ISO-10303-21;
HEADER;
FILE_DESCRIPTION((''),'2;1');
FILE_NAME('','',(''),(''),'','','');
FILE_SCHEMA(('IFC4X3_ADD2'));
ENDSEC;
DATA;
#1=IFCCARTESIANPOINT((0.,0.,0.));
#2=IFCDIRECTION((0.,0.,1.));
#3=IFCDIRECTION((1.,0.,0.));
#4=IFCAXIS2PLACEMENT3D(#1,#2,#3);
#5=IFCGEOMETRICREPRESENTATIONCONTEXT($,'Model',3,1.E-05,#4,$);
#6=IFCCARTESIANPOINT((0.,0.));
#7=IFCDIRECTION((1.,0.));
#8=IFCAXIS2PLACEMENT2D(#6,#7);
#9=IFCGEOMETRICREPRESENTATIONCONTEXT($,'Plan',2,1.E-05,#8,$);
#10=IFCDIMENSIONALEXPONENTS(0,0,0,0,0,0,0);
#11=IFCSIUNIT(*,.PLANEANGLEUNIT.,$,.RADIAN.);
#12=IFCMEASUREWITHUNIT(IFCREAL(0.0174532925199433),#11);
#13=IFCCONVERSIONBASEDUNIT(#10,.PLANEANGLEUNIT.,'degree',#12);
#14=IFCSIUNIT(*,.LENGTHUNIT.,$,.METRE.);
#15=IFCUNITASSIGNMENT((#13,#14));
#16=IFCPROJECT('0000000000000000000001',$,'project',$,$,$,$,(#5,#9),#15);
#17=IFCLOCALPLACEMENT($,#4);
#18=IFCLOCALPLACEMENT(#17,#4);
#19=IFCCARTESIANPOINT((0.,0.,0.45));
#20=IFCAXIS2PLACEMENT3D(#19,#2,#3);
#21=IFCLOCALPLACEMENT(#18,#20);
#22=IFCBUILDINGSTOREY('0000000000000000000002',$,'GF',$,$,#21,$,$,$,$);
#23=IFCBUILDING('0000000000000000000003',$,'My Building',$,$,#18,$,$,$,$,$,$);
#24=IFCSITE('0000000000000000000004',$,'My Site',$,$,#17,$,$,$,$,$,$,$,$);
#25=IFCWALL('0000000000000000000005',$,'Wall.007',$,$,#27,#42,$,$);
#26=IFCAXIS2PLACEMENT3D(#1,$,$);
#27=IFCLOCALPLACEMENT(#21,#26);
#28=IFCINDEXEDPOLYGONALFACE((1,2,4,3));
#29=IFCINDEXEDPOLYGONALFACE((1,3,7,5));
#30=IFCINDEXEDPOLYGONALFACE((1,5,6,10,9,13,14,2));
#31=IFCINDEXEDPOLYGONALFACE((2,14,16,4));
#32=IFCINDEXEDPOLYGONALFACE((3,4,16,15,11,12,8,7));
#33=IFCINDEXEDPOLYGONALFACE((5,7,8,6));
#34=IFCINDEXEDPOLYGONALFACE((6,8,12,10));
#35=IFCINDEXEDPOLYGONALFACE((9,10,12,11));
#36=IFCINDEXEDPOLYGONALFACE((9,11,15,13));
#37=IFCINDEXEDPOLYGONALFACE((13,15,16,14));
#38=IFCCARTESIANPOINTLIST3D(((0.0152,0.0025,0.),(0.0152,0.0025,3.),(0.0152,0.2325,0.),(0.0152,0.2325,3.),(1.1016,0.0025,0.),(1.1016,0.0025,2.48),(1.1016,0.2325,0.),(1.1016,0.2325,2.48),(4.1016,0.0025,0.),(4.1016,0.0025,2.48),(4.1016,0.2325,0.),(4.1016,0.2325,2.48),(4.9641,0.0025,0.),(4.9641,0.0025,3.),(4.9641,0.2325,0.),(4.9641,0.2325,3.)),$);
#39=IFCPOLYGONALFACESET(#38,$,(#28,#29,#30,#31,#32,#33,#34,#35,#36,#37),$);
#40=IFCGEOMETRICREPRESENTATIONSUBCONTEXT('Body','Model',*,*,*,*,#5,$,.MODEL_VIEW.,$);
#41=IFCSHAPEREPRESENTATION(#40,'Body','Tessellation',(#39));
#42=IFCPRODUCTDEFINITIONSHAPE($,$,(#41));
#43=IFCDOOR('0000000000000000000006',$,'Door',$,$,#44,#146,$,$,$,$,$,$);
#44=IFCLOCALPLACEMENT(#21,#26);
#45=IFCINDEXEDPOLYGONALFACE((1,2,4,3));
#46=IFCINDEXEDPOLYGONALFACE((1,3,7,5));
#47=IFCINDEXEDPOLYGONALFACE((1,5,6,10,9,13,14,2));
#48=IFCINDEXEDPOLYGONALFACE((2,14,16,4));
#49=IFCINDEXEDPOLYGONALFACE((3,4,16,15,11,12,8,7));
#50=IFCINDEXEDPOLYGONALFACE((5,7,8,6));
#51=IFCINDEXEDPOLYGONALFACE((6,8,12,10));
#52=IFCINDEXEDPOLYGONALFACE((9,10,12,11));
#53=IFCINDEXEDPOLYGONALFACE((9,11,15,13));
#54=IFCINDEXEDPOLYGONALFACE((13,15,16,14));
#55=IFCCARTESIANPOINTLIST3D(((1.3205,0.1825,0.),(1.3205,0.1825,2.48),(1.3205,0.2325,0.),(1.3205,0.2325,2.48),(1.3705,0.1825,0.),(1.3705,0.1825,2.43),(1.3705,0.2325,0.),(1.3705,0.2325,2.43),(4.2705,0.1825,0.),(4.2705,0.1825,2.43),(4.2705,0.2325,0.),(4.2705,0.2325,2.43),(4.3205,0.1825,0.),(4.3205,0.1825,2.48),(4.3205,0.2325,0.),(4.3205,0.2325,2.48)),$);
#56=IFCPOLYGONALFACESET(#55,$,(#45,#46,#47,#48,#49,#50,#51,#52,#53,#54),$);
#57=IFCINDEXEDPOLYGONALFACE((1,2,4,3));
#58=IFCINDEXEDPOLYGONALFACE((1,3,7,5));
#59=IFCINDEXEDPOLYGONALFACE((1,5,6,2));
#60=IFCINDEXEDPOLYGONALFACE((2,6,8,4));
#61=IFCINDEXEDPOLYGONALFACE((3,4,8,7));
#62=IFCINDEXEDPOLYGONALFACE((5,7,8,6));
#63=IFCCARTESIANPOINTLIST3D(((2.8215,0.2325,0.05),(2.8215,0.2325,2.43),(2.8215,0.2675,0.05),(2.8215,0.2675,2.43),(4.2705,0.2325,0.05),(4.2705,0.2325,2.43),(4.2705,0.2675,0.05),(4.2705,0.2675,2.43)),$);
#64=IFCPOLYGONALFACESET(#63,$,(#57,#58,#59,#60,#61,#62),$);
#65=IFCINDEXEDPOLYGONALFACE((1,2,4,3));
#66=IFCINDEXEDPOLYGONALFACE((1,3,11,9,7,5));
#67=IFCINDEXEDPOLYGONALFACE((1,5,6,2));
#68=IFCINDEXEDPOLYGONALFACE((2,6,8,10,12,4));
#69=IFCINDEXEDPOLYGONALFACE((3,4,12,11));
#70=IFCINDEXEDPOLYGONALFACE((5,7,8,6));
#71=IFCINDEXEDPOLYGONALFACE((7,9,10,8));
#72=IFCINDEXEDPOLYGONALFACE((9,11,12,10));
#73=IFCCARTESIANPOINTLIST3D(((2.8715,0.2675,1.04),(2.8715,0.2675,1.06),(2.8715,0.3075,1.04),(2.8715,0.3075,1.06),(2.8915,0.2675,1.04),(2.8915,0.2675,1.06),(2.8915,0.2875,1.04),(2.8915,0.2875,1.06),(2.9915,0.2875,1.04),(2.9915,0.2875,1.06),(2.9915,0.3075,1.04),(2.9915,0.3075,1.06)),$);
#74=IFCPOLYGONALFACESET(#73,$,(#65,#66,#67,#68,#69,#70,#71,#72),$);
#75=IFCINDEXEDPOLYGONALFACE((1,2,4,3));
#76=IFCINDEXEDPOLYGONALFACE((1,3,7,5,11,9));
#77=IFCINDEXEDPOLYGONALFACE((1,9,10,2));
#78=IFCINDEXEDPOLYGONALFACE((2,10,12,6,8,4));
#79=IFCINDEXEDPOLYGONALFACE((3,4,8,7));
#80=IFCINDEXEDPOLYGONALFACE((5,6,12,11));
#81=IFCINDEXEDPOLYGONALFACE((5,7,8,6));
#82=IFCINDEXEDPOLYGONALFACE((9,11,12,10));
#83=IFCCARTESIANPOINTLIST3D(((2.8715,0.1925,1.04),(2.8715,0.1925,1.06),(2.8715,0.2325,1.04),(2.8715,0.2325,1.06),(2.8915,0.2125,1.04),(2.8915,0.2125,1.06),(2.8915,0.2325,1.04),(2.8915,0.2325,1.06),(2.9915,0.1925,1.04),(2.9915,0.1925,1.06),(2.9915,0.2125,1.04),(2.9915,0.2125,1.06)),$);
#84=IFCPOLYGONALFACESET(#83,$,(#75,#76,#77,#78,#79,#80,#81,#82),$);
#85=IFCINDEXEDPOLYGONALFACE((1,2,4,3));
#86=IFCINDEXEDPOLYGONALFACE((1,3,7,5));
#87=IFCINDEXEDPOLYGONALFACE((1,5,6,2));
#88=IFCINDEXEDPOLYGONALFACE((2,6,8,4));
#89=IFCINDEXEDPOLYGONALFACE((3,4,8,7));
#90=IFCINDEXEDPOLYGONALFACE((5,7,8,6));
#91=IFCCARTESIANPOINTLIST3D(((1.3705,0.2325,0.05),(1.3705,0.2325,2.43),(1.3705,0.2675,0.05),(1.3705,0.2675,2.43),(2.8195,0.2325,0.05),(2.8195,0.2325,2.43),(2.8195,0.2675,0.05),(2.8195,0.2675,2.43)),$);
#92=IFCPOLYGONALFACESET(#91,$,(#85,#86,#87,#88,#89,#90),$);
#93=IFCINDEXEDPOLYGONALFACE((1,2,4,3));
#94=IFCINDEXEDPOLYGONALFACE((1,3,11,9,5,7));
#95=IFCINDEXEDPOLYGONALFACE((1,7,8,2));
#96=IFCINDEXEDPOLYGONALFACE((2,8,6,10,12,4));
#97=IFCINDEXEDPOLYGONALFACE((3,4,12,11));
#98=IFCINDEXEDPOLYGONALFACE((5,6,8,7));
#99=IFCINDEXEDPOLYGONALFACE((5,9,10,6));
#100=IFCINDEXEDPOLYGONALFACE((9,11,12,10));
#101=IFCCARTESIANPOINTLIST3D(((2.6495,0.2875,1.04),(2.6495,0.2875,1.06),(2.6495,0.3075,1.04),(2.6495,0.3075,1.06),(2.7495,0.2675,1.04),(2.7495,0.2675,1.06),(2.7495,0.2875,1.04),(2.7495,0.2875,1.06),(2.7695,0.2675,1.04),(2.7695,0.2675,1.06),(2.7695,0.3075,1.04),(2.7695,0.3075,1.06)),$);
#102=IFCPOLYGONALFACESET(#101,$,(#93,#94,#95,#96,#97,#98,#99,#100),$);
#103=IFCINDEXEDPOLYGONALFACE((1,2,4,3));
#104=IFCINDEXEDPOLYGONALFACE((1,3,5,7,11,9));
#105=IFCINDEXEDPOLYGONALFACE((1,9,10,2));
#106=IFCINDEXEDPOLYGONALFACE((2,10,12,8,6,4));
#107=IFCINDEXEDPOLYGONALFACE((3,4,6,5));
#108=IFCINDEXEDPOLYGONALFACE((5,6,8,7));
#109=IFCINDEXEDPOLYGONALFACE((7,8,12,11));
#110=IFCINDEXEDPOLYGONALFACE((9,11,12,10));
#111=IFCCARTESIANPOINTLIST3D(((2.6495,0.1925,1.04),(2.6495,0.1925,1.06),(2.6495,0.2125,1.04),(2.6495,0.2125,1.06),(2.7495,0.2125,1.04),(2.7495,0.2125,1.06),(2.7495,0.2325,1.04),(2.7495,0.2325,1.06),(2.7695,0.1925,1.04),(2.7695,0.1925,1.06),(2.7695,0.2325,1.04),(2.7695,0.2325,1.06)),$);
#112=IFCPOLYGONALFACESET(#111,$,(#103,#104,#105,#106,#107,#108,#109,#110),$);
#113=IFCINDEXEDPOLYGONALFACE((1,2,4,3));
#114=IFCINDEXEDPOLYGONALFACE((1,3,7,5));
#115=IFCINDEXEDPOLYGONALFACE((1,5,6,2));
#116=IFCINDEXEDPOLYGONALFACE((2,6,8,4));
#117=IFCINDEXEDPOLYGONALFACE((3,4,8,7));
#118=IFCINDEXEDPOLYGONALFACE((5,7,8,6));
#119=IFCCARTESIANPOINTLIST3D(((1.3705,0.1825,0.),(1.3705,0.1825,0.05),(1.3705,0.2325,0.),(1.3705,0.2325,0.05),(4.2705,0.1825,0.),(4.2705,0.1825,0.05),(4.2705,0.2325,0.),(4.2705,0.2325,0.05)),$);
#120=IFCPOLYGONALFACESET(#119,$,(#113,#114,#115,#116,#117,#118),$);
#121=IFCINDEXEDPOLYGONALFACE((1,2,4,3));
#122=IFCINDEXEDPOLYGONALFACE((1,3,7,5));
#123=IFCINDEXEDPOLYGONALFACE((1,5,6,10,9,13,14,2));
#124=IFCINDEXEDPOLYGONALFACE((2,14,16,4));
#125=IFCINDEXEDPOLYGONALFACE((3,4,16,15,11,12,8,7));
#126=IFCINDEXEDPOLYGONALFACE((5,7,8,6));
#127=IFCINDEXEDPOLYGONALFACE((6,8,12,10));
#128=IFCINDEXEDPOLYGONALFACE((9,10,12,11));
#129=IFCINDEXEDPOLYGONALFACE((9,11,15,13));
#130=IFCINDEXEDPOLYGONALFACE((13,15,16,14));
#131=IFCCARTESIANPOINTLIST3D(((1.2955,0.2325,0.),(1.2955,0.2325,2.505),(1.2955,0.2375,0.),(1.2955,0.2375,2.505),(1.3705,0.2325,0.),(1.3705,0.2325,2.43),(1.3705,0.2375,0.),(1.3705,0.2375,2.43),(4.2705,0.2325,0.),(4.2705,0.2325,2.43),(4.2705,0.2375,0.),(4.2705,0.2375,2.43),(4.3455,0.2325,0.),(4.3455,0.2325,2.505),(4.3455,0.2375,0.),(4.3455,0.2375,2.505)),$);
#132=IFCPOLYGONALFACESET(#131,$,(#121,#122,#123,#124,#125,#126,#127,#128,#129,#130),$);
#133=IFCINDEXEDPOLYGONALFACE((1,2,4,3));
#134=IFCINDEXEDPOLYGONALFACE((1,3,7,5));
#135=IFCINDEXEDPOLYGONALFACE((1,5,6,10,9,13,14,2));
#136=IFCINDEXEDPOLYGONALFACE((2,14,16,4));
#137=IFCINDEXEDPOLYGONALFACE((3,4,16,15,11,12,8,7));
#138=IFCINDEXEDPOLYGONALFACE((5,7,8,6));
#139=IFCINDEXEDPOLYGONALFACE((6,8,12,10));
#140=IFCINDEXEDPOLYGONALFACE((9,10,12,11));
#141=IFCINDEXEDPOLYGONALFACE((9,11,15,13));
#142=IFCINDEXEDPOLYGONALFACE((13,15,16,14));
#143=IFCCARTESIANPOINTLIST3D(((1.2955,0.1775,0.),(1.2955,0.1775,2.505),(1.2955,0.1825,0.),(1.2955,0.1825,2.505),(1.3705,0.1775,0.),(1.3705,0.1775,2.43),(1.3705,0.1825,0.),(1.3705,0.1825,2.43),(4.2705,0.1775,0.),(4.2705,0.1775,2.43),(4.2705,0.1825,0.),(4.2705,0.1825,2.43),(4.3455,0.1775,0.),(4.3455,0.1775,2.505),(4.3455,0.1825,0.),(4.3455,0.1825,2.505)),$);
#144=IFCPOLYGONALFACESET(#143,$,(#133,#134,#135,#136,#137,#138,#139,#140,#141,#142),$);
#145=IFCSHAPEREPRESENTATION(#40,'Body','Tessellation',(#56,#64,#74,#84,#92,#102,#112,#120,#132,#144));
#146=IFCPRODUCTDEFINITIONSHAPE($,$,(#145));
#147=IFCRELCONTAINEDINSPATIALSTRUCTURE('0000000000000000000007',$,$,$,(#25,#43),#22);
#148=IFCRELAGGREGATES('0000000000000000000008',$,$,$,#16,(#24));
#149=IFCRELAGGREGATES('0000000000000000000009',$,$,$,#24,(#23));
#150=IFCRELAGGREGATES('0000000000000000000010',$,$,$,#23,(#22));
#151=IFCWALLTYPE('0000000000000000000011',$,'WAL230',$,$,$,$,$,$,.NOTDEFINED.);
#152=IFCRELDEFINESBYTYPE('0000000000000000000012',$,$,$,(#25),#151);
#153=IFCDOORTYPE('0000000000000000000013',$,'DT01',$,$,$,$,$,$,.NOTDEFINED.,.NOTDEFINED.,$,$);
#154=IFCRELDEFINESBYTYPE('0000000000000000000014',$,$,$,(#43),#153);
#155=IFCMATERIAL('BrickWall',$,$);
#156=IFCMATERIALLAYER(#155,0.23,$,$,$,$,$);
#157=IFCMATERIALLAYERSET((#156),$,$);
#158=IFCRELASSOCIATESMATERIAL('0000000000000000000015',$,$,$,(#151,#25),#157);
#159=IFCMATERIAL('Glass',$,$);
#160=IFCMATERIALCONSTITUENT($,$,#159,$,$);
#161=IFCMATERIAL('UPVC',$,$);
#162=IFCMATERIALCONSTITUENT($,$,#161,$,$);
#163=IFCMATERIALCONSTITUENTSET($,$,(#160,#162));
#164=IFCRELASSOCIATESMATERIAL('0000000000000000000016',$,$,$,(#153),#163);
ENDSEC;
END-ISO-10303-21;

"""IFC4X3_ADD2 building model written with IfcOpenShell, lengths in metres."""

from ifc_helpers import new_model, entity, si_unit, converted_unit, frame, origin_with_axes, origin_2d_with_axis, place, context, subcontext, project, spatial, line, indexed_curve, outline, extrude, shape, source, transform, mapped, material, layer, layer_set, layer_usage, constituent, constituent_set, type_object, type_shapes, element, fill, save


model = new_model("IFC4X3_ADD2")

# Units and contexts
model_context = context("Model", 3, precision=1e-05, world=origin_with_axes())
plan_context = context("Plan", 2, precision=1e-05, world=origin_2d_with_axis())
body_context_1 = subcontext(model_context, "Body", "Model", "MODEL_VIEW")
body_context_2 = subcontext(plan_context, "Body", "Plan", "PLAN_VIEW")
ifc_project = project(units=[converted_unit("PLANEANGLEUNIT", "degree", entity("IfcReal", 0.0174532925199433), si_unit("PLANEANGLEUNIT", "RADIAN"), dimensions=[0, 0, 0, 0, 0, 0, 0]), si_unit("LENGTHUNIT", "METRE")], contexts=[model_context, plan_context])

# Site, building, storey
site_placement = place(None, origin_with_axes())
site = spatial("IfcSite", under=ifc_project, at=site_placement, Name="My Site")
building_placement = place(site_placement, origin_with_axes())
building = spatial("IfcBuilding", under=site, at=building_placement, Name="My Building")
storey_placement = place(building_placement, frame((0.0, 0.0, 0.45), z_axis=(0.0, 0.0, 1.0), x_axis=(1.0, 0.0, 0.0)))
storey = spatial("IfcBuildingStorey", under=building, at=storey_placement, Name="GF")

# Shared definitions
ifc_material_1 = material(Name="BrickWall")

# Shared definitions
ifc_layer_1 = layer(ifc_material_1, 0.23)
ifc_layer_set_1 = layer_set([ifc_layer_1])
wall_type_1 = type_object("IfcWallType", Name="WAL230", PredefinedType="NOTDEFINED", material=ifc_layer_set_1)
shared_shape_1 = source(origin_with_axes(), body_context_1, "Body", "SweptSolid", [
    extrude(outline(indexed_curve([(0.0, 0.0), (3.0, 0.0), (3.0, 2.48), (0.0, 2.48)], segments=[line(1, 2, 3, 4, 1)])), frame((0.0, -0.6, 0.0), z_axis=(0.0, -1.0, 0.0), x_axis=(1.0, 0.0, 0.0)), (0.0, 0.0, -1.0), 1.2),
])
ifc_material_2 = material(Name="Glass")
ifc_constituent_1 = constituent(ifc_material_2)
ifc_material_3 = material(Name="UPVC")
ifc_constituent_2 = constituent(ifc_material_3)
ifc_constituent_set = constituent_set(constituents=[ifc_constituent_1, ifc_constituent_2])
door_type_1 = type_object("IfcDoorType", Name="DT01", OperationType="NOTDEFINED", PredefinedType="NOTDEFINED", material=ifc_constituent_set)
shared_shape_2 = source(origin_with_axes(), body_context_1, "Body", "SweptSolid", [
    extrude(outline(indexed_curve([(3.0, 0.0), (3.0, 2.48), (0.0, 2.48), (0.0, 0.0), (0.05, 0.0), (0.05, 2.43), (2.95, 2.43), (2.95, 0.0)], segments=[line(5, 4), line(4, 3), line(3, 2), line(2, 1), line(1, 8), line(8, 7), line(7, 6), line(6, 5)], self_intersect=False)), frame((0.0, 0.0, 0.0), z_axis=(0.0, -1.0, 0.0), x_axis=(1.0, 0.0, 0.0)), (0.0, 0.0, -1.0), 0.05),
    extrude(outline(indexed_curve([(0.0, 0.0), (1.449, 0.0), (1.449, 0.035), (0.0, 0.035)], segments=[line(1, 2, 3, 4, 1)])), frame((0.05, -0.035, 0.05), z_axis=(0.0, 0.0, 1.0), x_axis=(1.0, 0.0, 0.0)), (0.0, 0.0, 1.0), 2.38),
    extrude(outline(indexed_curve([(0.0, 0.0), (0.0, -0.04), (-0.12, -0.04), (-0.12, -0.02), (-0.02, -0.02), (-0.02, 0.0)], segments=[line(1, 2, 3, 4, 5, 6, 1)])), frame((1.449, -0.035, 1.04), z_axis=(0.0, 0.0, 1.0), x_axis=(1.0, 0.0, 0.0)), (0.0, 0.0, 1.0), 0.02),
    extrude(outline(indexed_curve([(0.0, 0.0), (0.0, 0.04), (-0.12, 0.04), (-0.12, 0.02), (-0.02, 0.02), (-0.02, 0.0)], segments=[line(1, 2, 3, 4, 5, 6, 1)])), frame((1.449, 0.0, 1.04), z_axis=(0.0, 0.0, 1.0), x_axis=(1.0, 0.0, 0.0)), (0.0, 0.0, 1.0), 0.02),
    extrude(outline(indexed_curve([(0.0, 0.0), (-1.449, 0.0), (-1.449, 0.035), (0.0, 0.035)], segments=[line(1, 2, 3, 4, 1)])), frame((2.95, -0.035, 0.05), z_axis=(0.0, 0.0, 1.0), x_axis=(1.0, 0.0, 0.0)), (0.0, 0.0, 1.0), 2.38),
    extrude(outline(indexed_curve([(0.0, 0.0), (0.0, -0.04), (0.12, -0.04), (0.12, -0.02), (0.02, -0.02), (0.02, 0.0)], segments=[line(1, 2, 3, 4, 5, 6, 1)])), frame((1.551, -0.035, 1.04), z_axis=(0.0, 0.0, 1.0), x_axis=(1.0, 0.0, 0.0)), (0.0, 0.0, 1.0), 0.02),
    extrude(outline(indexed_curve([(0.0, 0.0), (0.0, 0.04), (0.12, 0.04), (0.12, 0.02), (0.02, 0.02), (0.02, 0.0)], segments=[line(1, 2, 3, 4, 5, 6, 1)])), frame((1.551, 0.0, 1.04), z_axis=(0.0, 0.0, 1.0), x_axis=(1.0, 0.0, 0.0)), (0.0, 0.0, 1.0), 0.02),
    extrude(outline(indexed_curve([(0.0, 0.0), (2.9, 0.0), (2.9, 0.05), (0.0, 0.05)], segments=[line(1, 2, 3, 4, 1)])), frame((0.05, 0.0, 0.0), z_axis=(0.0, 0.0, 1.0), x_axis=(1.0, 0.0, 0.0)), (0.0, 0.0, 1.0), 0.05),
    extrude(outline(indexed_curve([(0.0, 0.0), (0.0, 2.505), (3.05, 2.505), (3.05, 0.0), (2.975, 0.0), (2.975, 2.43), (0.075, 2.43), (0.075, 0.0)], segments=[line(1, 2, 3, 4, 5, 6, 7, 8, 1)])), frame((-0.025, -0.005, 0.0), z_axis=(0.0, -1.0, 0.0), x_axis=(1.0, 0.0, 0.0)), (0.0, 0.0, -1.0), 0.005),
    extrude(outline(indexed_curve([(0.0, 0.0), (0.0, 2.505), (3.05, 2.505), (3.05, 0.0), (2.975, 0.0), (2.975, 2.43), (0.075, 2.43), (0.075, 0.0)], segments=[line(1, 2, 3, 4, 5, 6, 7, 8, 1)])), frame((-0.025, 0.05, 0.0), z_axis=(0.0, -1.0, 0.0), x_axis=(1.0, 0.0, 0.0)), (0.0, 0.0, -1.0), 0.005),
])
shared_shape_3 = source(origin_with_axes(), body_context_2, "Body", "Curve2D", [
    entity("IfcIndexedPolyCurve", entity("IfcCartesianPointList2D", [[0.0, 0.0], [0.05, 0.0], [0.05, 0.05], [0.0, 0.05]]), [entity("IfcLineIndex", [1, 2, 3, 4, 1])]),
    entity("IfcIndexedPolyCurve", entity("IfcCartesianPointList2D", [[3.0, 0.0], [2.95, 0.0], [2.95, 0.05], [3.0, 0.05]]), [entity("IfcLineIndex", [1, 2, 3, 4, 1])]),
    entity("IfcIndexedPolyCurve", entity("IfcCartesianPointList2D", [[-0.675, -0.035], [0.775, -0.035], [0.775, 0.0], [-0.675, 0.0]]), [entity("IfcLineIndex", [1, 2, 3, 4, 1])]),
    entity("IfcIndexedPolyCurve", entity("IfcCartesianPointList2D", [[3.675, -0.035], [2.225, -0.035], [2.225, 0.0], [3.675, 0.0]]), [entity("IfcLineIndex", [1, 2, 3, 4, 1])]),
])
type_shapes(door_type_1, [shared_shape_2, shared_shape_3])

# Wall, opening, door
ifc_layer_usage_1 = layer_usage(ifc_layer_set_1, "AXIS2", "POSITIVE", 0.0)
wall_1_placement = place(storey_placement, frame((4.9641, 0.2325, 0.0), z_axis=(0.0, 0.0, 1.0), x_axis=(-1.0, 0.0, 0.0)))
wall_1 = element("IfcWall", 1, at=wall_1_placement, inside=storey, type_object=wall_type_1, material=ifc_layer_usage_1, Name="Wall.007", context=body_context_1, shape_type="SweptSolid", body=[
    extrude(outline(indexed_curve([(0.0, 0.0), (0.0, 0.23), (4.9489, 0.23), (4.9489, 0.0), (0.0, 0.0)], self_intersect=False)), origin_with_axes(), (0.0, 0.0, 1.0), 3.0),
])
opening_1_placement = place(wall_1_placement, frame((0.8625, 0.0175, 0.0), z_axis=(0.0, 0.0, 1.0), x_axis=(1.0, 0.0, 0.0)))
opening_1 = element("IfcOpeningElement", 2, at=opening_1_placement, cuts=wall_1, PredefinedType="OPENING", context=body_context_1, shape_type="MappedRepresentation", body=[
    mapped(shared_shape_1, transform((0.0, 0.0, 0.0), x_axis=(1.0, 0.0, 0.0), y_axis=(0.0, 1.0, 0.0), z_axis=(0.0, 0.0, 1.0), scale=1.0)),
])
door_1_placement = place(opening_1_placement, frame((-0.2189, -0.0175, 0.0), z_axis=(0.0, 0.0, 1.0), x_axis=(1.0, 0.0, 0.0)))
door_1 = element("IfcDoor", 3, at=door_1_placement, inside=storey, type_object=door_type_1, Name="Door", shapes=[
    shape(body_context_1, "Body", "MappedRepresentation", [mapped(shared_shape_2, transform((0.0, 0.0, 0.0), x_axis=(1.0, 0.0, 0.0), y_axis=(0.0, 1.0, 0.0), z_axis=(0.0, 0.0, 1.0), scale=1.0))]),
    shape(body_context_2, "Body", "MappedRepresentation", [mapped(shared_shape_3, transform((0.0, 0.0, 0.0), x_axis=(1.0, 0.0, 0.0), y_axis=(0.0, 1.0, 0.0), z_axis=(0.0, 0.0, 1.0), scale=1.0))]),
])
fill(opening_1, door_1)

save(model, "model.ifc")
